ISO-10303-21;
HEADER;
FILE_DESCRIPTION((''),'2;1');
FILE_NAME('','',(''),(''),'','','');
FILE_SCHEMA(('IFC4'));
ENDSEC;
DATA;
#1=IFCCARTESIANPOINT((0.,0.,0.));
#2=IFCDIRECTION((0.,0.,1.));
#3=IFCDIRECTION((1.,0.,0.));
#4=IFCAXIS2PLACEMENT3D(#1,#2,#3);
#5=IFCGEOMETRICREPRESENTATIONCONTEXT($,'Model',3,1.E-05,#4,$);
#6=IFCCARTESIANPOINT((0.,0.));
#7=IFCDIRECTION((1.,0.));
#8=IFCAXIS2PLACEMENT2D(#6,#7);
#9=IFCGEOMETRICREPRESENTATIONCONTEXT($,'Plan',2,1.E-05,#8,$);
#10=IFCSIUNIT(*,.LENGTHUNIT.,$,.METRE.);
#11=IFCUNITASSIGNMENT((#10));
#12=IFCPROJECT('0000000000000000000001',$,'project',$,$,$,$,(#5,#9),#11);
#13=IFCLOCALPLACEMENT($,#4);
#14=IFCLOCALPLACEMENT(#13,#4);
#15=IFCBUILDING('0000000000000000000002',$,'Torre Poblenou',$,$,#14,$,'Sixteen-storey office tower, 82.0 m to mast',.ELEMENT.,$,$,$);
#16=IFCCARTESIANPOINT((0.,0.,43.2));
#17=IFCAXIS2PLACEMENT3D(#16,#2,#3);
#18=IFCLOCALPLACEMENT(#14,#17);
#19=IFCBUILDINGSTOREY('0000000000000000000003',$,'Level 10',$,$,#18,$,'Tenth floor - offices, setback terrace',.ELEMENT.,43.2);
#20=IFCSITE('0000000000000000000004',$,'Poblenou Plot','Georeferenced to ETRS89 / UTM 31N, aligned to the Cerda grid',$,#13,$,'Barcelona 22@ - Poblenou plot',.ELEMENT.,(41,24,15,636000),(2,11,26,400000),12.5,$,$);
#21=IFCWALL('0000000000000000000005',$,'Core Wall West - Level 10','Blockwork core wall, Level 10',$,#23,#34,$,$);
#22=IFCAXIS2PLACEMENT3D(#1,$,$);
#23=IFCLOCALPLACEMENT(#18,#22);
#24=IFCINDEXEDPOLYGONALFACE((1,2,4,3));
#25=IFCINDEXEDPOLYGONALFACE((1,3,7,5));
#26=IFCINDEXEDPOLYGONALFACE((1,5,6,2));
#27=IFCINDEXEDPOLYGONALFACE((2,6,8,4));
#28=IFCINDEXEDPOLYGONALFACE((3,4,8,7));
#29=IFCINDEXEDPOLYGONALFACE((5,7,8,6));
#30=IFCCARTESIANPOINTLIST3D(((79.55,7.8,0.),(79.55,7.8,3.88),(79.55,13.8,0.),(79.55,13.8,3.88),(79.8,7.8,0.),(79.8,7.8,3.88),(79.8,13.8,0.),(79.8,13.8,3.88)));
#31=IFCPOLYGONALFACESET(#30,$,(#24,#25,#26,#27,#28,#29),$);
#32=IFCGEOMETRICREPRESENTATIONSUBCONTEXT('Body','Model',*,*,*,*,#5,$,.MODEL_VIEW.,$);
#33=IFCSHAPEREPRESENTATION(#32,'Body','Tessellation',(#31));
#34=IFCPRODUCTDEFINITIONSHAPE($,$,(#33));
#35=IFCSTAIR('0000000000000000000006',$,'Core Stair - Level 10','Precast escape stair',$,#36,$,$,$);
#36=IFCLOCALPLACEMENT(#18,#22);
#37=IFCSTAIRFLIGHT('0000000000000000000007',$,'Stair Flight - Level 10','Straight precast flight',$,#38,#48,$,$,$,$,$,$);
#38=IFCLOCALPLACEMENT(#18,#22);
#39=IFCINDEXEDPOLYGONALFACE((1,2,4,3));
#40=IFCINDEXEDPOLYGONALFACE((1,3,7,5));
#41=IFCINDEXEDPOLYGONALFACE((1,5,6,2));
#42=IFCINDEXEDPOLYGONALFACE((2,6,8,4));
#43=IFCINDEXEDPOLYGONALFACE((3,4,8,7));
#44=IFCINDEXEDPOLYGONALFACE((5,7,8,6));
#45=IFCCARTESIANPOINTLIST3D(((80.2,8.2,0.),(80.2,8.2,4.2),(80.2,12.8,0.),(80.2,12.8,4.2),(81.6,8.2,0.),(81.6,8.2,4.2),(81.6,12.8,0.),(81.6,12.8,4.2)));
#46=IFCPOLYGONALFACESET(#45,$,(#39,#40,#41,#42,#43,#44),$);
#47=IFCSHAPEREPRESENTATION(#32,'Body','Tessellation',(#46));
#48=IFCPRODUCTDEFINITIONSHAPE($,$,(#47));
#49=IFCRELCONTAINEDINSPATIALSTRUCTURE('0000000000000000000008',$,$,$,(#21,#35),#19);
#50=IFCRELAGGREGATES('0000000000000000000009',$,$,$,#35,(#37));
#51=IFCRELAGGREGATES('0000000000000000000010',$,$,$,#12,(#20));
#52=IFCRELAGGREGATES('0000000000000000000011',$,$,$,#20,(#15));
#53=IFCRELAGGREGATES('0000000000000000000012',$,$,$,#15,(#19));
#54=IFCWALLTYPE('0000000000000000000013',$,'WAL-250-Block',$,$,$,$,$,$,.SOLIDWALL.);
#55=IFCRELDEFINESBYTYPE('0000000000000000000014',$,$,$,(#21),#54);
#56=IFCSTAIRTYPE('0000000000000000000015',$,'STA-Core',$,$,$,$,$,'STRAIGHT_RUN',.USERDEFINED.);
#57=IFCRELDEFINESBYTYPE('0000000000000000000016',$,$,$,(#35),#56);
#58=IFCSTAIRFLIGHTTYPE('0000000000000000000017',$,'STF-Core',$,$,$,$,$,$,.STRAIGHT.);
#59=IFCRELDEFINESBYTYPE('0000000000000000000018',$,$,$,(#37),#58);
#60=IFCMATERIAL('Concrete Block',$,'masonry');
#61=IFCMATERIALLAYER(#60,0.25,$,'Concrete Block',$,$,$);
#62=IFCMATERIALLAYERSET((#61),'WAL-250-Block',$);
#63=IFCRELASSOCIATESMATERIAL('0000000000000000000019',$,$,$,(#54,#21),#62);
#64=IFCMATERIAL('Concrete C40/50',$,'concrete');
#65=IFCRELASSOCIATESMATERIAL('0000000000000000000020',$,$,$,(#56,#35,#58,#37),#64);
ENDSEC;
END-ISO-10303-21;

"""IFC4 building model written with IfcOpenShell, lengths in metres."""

from ifc_helpers import new_model, si_unit, frame, origin_with_axes, origin_2d_with_axis, place, context, subcontext, project, spatial, line, indexed_curve, outline, extrude, material, layer, layer_set, layer_usage, type_object, element, aggregate, save


model = new_model("IFC4")

# Units and contexts
model_context = context("Model", 3, precision=1e-05, world=origin_with_axes())
plan_context = context("Plan", 2, precision=1e-05, world=origin_2d_with_axis())
body_context = subcontext(model_context, "Body", "Model", "MODEL_VIEW")
ifc_project = project(units=[si_unit("LENGTHUNIT", "METRE")], contexts=[model_context, plan_context])

# Site, building, storey
site_placement = place(None, origin_with_axes())
site = spatial("IfcSite", under=ifc_project, at=site_placement, Name="Poblenou Plot", Description="Georeferenced to ETRS89 / UTM 31N, aligned to the Cerda grid", LongName="Barcelona 22@ - Poblenou plot", CompositionType="ELEMENT", RefLatitude=(41, 24, 15, 636000), RefLongitude=(2, 11, 26, 400000), RefElevation=12.5)
building_placement = place(site_placement, origin_with_axes())
building = spatial("IfcBuilding", under=site, at=building_placement, Name="Torre Poblenou", LongName="Sixteen-storey office tower, 82.0 m to mast", CompositionType="ELEMENT")
storey_placement = place(building_placement, frame((0.0, 0.0, 43.2), z_axis=(0.0, 0.0, 1.0), x_axis=(1.0, 0.0, 0.0)))
storey = spatial("IfcBuildingStorey", under=building, at=storey_placement, Name="Level 10", LongName="Tenth floor - offices, setback terrace", CompositionType="ELEMENT", Elevation=43.2)

# Shared definitions
ifc_material_1 = material(Name="Concrete C40/50", Category="concrete")

# Wall
ifc_material_2 = material(Name="Concrete Block", Category="masonry")
ifc_layer_1 = layer(ifc_material_2, 0.25, Name="Concrete Block")
ifc_layer_set_1 = layer_set([ifc_layer_1], Name="WAL-250-Block")
wall_type = type_object("IfcWallType", Name="WAL-250-Block", PredefinedType="SOLIDWALL", material=ifc_layer_set_1)
ifc_layer_usage_1 = layer_usage(ifc_layer_set_1, "AXIS2", "POSITIVE", 0.0)
wall_1_placement = place(storey_placement, frame((79.8, 7.8, 0.0), z_axis=(0.0, 0.0, 1.0), x_axis=(0.0, 1.0, 0.0)))
element("IfcWall", 1, at=wall_1_placement, inside=storey, type_object=wall_type, material=ifc_layer_usage_1, Name="Core Wall West - Level 10", Description="Blockwork core wall, Level 10", context=body_context, shape_type="SweptSolid", body=[
    extrude(outline(indexed_curve([(0.0, 0.0), (6.0, 0.0), (6.0, 0.25), (0.0, 0.25)], segments=[line(1, 2, 3, 4, 1)])), origin_with_axes(), (0.0, 0.0, 1.0), 3.88),
])

# Stair, stair flight
stair_type = type_object("IfcStairType", Name="STA-Core", ElementType="STRAIGHT_RUN", PredefinedType="USERDEFINED", material=ifc_material_1)
stair_placement = place(storey_placement, frame((80.2, 8.2, 0.0), z_axis=(0.0, 0.0, 1.0), x_axis=(1.0, 0.0, 0.0)))
stair = element("IfcStair", 2, at=stair_placement, inside=storey, type_object=stair_type, material=ifc_material_1, Name="Core Stair - Level 10", Description="Precast escape stair")
stair_flight_type = type_object("IfcStairFlightType", Name="STF-Core", PredefinedType="STRAIGHT", material=ifc_material_1)
stair_flight_placement = place(stair_placement, origin_with_axes())
stair_flight = element("IfcStairFlight", 3, at=stair_flight_placement, type_object=stair_flight_type, material=ifc_material_1, Name="Stair Flight - Level 10", Description="Straight precast flight", context=body_context, shape_type="SweptSolid", body=[
    extrude(outline(indexed_curve([(0.0, 0.0), (1.4, 0.0), (1.4, 4.6), (0.0, 4.6)], segments=[line(1, 2, 3, 4, 1)])), origin_with_axes(), (0.0, 0.0, 1.0), 4.2),
])
aggregate(stair, [stair_flight])

save(model, "model.ifc")
